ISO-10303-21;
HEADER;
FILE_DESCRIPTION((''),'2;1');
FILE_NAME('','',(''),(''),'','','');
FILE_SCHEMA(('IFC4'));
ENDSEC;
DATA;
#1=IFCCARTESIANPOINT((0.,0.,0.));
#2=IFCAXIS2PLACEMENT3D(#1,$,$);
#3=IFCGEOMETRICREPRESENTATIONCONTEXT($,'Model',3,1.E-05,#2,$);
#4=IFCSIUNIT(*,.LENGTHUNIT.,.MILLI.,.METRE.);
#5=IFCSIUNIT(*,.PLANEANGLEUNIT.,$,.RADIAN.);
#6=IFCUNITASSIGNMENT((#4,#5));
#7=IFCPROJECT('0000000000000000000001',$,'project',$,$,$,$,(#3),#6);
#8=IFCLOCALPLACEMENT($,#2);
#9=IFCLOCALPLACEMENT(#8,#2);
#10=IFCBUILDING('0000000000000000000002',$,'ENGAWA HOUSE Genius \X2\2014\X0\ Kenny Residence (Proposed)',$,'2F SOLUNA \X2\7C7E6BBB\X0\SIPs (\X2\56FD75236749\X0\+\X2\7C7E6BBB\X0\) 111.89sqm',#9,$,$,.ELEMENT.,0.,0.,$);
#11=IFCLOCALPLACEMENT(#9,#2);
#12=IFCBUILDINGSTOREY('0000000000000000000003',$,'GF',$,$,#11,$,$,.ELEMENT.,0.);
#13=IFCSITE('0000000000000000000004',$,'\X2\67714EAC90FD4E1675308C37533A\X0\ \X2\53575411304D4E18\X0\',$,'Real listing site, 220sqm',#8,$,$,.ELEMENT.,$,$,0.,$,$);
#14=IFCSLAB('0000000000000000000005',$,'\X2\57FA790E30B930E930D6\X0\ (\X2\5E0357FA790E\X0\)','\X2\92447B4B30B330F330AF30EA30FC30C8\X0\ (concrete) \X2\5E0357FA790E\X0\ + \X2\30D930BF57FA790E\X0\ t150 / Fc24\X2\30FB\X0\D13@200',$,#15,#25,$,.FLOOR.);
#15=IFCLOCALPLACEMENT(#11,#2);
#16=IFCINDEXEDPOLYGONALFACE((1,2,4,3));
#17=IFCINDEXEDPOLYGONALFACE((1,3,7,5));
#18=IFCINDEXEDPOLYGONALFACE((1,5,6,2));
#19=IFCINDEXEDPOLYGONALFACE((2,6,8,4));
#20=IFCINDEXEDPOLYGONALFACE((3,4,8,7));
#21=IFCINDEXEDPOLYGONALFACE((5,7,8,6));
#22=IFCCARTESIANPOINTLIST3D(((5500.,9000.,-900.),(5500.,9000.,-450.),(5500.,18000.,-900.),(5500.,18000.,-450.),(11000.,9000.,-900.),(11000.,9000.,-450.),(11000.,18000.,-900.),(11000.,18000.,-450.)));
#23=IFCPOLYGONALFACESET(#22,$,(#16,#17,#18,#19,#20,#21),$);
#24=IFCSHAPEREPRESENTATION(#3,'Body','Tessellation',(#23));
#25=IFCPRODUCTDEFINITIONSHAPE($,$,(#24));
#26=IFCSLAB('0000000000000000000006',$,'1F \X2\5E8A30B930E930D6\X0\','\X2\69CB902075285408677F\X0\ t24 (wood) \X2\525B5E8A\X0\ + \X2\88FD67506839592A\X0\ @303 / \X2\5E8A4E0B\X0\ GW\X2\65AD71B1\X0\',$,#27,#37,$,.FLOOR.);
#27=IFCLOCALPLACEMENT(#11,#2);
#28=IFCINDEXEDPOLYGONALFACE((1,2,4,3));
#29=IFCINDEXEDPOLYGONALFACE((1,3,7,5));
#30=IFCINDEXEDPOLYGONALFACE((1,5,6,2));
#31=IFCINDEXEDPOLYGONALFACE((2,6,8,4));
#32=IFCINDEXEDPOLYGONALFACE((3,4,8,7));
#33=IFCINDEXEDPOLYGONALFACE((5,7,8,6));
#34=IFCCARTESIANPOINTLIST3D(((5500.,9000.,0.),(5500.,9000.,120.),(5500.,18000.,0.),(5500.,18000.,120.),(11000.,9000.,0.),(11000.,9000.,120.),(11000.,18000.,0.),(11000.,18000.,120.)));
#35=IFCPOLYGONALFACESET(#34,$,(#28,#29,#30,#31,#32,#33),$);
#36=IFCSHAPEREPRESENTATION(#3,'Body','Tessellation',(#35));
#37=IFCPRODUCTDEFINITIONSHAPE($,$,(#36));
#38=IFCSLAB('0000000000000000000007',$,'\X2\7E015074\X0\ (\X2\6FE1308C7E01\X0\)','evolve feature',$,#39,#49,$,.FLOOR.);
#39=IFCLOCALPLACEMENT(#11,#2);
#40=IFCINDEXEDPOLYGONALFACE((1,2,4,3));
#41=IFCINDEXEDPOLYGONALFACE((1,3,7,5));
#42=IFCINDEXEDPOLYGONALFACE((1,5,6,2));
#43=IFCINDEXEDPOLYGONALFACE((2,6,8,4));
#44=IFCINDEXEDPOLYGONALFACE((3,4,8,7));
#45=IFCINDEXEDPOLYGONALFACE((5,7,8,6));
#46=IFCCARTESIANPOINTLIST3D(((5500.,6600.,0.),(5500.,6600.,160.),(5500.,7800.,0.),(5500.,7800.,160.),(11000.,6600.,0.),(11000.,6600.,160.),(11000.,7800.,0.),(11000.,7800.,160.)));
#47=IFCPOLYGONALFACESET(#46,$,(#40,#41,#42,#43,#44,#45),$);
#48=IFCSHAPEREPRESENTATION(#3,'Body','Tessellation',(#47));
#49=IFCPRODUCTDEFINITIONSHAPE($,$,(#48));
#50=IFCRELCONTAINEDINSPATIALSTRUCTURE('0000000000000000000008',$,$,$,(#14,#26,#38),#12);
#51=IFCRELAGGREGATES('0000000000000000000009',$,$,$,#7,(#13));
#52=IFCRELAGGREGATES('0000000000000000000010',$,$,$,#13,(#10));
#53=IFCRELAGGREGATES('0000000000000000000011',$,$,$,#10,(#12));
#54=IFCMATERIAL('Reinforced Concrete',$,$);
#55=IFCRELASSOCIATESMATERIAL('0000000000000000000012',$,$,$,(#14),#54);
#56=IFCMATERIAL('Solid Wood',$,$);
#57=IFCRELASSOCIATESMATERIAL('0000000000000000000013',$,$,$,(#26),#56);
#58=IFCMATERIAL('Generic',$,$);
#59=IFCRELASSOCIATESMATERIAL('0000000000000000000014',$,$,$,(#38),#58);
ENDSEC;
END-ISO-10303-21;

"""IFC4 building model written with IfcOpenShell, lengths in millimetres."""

from ifc_helpers import new_model, si_unit, frame, frame_2d, origin, place, context, project, spatial, rectangle, extrude, material, element, save


model = new_model("IFC4")

# Units and contexts
model_context = context("Model", 3, precision=1e-05, world=origin())
ifc_project = project(units=[si_unit("LENGTHUNIT", "METRE", prefix="MILLI"), si_unit("PLANEANGLEUNIT", "RADIAN")], contexts=[model_context])

# Site, building, storey
site_placement = place(None, origin())
site = spatial("IfcSite", under=ifc_project, at=site_placement, Name="東京都世田谷区 南向き丘", ObjectType="Real listing site, 220sqm", CompositionType="ELEMENT", RefElevation=0.0)
building_placement = place(site_placement, origin())
building = spatial("IfcBuilding", under=site, at=building_placement, Name="ENGAWA HOUSE Genius — Kenny Residence (Proposed)", ObjectType="2F SOLUNA 籾殻SIPs (国産杉+籾殻) 111.89sqm", CompositionType="ELEMENT", ElevationOfRefHeight=0.0, ElevationOfTerrain=0.0)
storey_placement = place(building_placement, origin())
storey = spatial("IfcBuildingStorey", under=building, at=storey_placement, Name="GF", CompositionType="ELEMENT", Elevation=0.0)

# Slabs
ifc_material_1 = material(Name="Reinforced Concrete")
slab_1_placement = place(storey_placement, frame((2750.0, 4500.0, -450.0)))
element("IfcSlab", 1, at=slab_1_placement, inside=storey, material=ifc_material_1, Name="基礎スラブ (布基礎)", Description="鉄筋コンクリート (concrete) 布基礎 + ベタ基礎 t150 / Fc24・D13@200", PredefinedType="FLOOR", context=model_context, shape_type="SweptSolid", body=[
    extrude(rectangle(XDim=5500.0, YDim=9000.0, at=frame_2d((2750.0, 4500.0))), frame((2750.0, 4500.0, -450.0)), (0.0, 0.0, 1.0), 450.0),
])
ifc_material_2 = material(Name="Solid Wood")
slab_2_placement = place(storey_placement, frame((2750.0, 4500.0, 0.0)))
element("IfcSlab", 2, at=slab_2_placement, inside=storey, material=ifc_material_2, Name="1F 床スラブ", Description="構造用合板 t24 (wood) 剛床 + 製材根太 @303 / 床下 GW断熱", PredefinedType="FLOOR", context=model_context, shape_type="SweptSolid", body=[
    extrude(rectangle(XDim=5500.0, YDim=9000.0, at=frame_2d((2750.0, 4500.0))), frame((2750.0, 4500.0, 0.0)), (0.0, 0.0, 1.0), 120.0),
])
ifc_material_3 = material(Name="Generic")
slab_3_placement = place(storey_placement, frame((2750.0, 3300.0, 0.0)))
element("IfcSlab", 3, at=slab_3_placement, inside=storey, material=ifc_material_3, Name="縁側 (濡れ縁)", Description="evolve feature", PredefinedType="FLOOR", context=model_context, shape_type="SweptSolid", body=[
    extrude(rectangle(XDim=5500.0, YDim=1200.0, at=frame_2d((2750.0, 600.0))), frame((2750.0, 3300.0, 0.0)), (0.0, 0.0, 1.0), 160.0),
])

save(model, "model.ifc")
